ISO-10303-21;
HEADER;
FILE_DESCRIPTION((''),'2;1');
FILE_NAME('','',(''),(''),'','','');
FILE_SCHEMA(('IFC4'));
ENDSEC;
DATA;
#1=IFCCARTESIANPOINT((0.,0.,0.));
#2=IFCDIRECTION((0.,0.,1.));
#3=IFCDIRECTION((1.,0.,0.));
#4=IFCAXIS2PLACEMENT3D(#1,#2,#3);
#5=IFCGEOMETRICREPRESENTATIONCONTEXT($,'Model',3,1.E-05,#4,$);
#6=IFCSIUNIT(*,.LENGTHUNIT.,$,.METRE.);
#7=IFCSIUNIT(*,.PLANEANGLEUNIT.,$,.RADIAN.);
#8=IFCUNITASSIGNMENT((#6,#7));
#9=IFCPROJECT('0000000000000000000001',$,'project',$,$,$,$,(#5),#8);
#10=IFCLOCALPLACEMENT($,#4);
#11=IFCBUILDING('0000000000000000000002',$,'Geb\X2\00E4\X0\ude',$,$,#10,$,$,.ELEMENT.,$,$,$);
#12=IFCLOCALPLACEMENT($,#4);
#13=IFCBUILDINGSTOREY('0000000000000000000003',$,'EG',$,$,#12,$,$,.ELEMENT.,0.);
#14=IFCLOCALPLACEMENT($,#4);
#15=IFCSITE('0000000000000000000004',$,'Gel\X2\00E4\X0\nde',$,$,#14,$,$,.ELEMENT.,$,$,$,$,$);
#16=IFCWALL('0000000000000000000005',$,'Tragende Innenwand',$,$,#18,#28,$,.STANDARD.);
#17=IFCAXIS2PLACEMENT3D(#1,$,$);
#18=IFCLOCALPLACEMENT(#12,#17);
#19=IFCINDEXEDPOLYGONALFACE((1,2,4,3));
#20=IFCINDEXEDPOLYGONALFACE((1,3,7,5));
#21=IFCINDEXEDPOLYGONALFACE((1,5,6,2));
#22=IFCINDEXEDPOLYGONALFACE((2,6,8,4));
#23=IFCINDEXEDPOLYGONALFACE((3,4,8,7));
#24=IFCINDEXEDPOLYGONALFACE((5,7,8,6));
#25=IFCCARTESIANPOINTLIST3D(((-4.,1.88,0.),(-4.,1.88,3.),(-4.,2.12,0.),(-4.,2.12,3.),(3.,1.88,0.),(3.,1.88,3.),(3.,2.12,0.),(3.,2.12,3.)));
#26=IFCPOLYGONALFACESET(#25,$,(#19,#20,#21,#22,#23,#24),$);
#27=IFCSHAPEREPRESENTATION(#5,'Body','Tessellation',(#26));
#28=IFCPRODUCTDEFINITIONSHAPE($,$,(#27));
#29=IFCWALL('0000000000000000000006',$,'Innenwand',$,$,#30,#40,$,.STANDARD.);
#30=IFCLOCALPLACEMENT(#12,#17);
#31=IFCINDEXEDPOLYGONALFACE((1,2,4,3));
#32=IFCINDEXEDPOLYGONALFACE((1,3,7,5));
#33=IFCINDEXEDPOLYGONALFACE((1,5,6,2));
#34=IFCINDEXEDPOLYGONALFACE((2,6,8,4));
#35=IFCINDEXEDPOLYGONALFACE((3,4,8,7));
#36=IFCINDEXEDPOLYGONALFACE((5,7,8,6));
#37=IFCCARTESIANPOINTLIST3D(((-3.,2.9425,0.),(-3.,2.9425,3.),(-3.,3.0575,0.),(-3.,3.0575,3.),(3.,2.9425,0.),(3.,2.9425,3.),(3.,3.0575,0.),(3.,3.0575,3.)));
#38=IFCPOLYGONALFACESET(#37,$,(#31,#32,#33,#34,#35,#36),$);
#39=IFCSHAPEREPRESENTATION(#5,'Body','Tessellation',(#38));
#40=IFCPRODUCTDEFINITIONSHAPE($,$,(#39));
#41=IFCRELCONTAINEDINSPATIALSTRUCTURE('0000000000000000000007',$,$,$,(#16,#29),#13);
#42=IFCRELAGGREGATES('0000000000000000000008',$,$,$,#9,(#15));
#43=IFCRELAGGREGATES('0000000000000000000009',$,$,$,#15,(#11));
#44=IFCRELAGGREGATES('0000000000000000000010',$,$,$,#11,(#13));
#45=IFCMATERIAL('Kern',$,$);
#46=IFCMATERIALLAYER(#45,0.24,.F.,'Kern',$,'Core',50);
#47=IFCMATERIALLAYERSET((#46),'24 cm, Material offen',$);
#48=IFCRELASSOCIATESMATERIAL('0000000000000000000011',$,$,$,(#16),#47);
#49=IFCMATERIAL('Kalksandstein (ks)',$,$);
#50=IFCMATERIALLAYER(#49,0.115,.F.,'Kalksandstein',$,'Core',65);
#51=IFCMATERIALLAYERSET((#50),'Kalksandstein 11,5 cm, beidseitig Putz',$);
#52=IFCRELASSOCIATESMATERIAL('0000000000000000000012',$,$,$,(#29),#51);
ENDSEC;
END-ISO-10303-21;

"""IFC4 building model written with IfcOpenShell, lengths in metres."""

from ifc_helpers import new_model, si_unit, frame, origin_with_axes, origin_2d, place, context, project, spatial, rectangle, extrude, material, layer, layer_set, layer_usage, element, save


model = new_model("IFC4")

# Units and contexts
model_context = context("Model", 3, precision=1e-05, world=origin_with_axes())
ifc_project = project(units=[si_unit("LENGTHUNIT", "METRE"), si_unit("PLANEANGLEUNIT", "RADIAN")], contexts=[model_context])

# Site, building, storey
site_placement = place(None, origin_with_axes())
site = spatial("IfcSite", under=ifc_project, at=site_placement, Name="Gelände", CompositionType="ELEMENT")
building_placement = place(None, origin_with_axes())
building = spatial("IfcBuilding", under=site, at=building_placement, Name="Gebäude", CompositionType="ELEMENT")
storey_placement = place(None, origin_with_axes())
storey = spatial("IfcBuildingStorey", under=building, at=storey_placement, Name="EG", CompositionType="ELEMENT", Elevation=0.0)

# Shared definitions
ifc_material_1 = material(Name="Kalksandstein (ks)")

# Walls
ifc_material_2 = material(Name="Kern")
ifc_layer_1 = layer(ifc_material_2, 0.24, ventilated=False, Name="Kern", Category="Core", Priority=50)
ifc_layer_set_1 = layer_set([ifc_layer_1], Name="24 cm, Material offen")
wall_1_placement = place(None, frame((-0.5, 2.0, 0.0), z_axis=(0.0, 0.0, 1.0), x_axis=(1.0, 0.0, 0.0)))
element("IfcWall", 1, at=wall_1_placement, inside=storey, material=ifc_layer_set_1, Name="Tragende Innenwand", PredefinedType="STANDARD", context=model_context, shape_type="SweptSolid", body=[
    extrude(rectangle(XDim=7.0, YDim=0.24, at=origin_2d()), origin_with_axes(), (0.0, 0.0, 1.0), 3.0),
])
ifc_layer_2 = layer(ifc_material_1, 0.115, ventilated=False, Name="Kalksandstein", Category="Core", Priority=65)
ifc_layer_set_2 = layer_set([ifc_layer_2], Name="Kalksandstein 11,5 cm, beidseitig Putz")
ifc_layer_usage_1 = layer_usage(ifc_layer_set_2, "AXIS2", "NEGATIVE", 0.0575)
wall_2_placement = place(None, frame((0.0, 3.0, 0.0), z_axis=(0.0, 0.0, 1.0), x_axis=(1.0, 0.0, 0.0)))
element("IfcWall", 2, at=wall_2_placement, inside=storey, material=ifc_layer_usage_1, Name="Innenwand", PredefinedType="STANDARD", context=model_context, shape_type="SweptSolid", body=[
    extrude(rectangle(XDim=6.0, YDim=0.115, at=origin_2d()), origin_with_axes(), (0.0, 0.0, 1.0), 3.0),
])

save(model, "model.ifc")
